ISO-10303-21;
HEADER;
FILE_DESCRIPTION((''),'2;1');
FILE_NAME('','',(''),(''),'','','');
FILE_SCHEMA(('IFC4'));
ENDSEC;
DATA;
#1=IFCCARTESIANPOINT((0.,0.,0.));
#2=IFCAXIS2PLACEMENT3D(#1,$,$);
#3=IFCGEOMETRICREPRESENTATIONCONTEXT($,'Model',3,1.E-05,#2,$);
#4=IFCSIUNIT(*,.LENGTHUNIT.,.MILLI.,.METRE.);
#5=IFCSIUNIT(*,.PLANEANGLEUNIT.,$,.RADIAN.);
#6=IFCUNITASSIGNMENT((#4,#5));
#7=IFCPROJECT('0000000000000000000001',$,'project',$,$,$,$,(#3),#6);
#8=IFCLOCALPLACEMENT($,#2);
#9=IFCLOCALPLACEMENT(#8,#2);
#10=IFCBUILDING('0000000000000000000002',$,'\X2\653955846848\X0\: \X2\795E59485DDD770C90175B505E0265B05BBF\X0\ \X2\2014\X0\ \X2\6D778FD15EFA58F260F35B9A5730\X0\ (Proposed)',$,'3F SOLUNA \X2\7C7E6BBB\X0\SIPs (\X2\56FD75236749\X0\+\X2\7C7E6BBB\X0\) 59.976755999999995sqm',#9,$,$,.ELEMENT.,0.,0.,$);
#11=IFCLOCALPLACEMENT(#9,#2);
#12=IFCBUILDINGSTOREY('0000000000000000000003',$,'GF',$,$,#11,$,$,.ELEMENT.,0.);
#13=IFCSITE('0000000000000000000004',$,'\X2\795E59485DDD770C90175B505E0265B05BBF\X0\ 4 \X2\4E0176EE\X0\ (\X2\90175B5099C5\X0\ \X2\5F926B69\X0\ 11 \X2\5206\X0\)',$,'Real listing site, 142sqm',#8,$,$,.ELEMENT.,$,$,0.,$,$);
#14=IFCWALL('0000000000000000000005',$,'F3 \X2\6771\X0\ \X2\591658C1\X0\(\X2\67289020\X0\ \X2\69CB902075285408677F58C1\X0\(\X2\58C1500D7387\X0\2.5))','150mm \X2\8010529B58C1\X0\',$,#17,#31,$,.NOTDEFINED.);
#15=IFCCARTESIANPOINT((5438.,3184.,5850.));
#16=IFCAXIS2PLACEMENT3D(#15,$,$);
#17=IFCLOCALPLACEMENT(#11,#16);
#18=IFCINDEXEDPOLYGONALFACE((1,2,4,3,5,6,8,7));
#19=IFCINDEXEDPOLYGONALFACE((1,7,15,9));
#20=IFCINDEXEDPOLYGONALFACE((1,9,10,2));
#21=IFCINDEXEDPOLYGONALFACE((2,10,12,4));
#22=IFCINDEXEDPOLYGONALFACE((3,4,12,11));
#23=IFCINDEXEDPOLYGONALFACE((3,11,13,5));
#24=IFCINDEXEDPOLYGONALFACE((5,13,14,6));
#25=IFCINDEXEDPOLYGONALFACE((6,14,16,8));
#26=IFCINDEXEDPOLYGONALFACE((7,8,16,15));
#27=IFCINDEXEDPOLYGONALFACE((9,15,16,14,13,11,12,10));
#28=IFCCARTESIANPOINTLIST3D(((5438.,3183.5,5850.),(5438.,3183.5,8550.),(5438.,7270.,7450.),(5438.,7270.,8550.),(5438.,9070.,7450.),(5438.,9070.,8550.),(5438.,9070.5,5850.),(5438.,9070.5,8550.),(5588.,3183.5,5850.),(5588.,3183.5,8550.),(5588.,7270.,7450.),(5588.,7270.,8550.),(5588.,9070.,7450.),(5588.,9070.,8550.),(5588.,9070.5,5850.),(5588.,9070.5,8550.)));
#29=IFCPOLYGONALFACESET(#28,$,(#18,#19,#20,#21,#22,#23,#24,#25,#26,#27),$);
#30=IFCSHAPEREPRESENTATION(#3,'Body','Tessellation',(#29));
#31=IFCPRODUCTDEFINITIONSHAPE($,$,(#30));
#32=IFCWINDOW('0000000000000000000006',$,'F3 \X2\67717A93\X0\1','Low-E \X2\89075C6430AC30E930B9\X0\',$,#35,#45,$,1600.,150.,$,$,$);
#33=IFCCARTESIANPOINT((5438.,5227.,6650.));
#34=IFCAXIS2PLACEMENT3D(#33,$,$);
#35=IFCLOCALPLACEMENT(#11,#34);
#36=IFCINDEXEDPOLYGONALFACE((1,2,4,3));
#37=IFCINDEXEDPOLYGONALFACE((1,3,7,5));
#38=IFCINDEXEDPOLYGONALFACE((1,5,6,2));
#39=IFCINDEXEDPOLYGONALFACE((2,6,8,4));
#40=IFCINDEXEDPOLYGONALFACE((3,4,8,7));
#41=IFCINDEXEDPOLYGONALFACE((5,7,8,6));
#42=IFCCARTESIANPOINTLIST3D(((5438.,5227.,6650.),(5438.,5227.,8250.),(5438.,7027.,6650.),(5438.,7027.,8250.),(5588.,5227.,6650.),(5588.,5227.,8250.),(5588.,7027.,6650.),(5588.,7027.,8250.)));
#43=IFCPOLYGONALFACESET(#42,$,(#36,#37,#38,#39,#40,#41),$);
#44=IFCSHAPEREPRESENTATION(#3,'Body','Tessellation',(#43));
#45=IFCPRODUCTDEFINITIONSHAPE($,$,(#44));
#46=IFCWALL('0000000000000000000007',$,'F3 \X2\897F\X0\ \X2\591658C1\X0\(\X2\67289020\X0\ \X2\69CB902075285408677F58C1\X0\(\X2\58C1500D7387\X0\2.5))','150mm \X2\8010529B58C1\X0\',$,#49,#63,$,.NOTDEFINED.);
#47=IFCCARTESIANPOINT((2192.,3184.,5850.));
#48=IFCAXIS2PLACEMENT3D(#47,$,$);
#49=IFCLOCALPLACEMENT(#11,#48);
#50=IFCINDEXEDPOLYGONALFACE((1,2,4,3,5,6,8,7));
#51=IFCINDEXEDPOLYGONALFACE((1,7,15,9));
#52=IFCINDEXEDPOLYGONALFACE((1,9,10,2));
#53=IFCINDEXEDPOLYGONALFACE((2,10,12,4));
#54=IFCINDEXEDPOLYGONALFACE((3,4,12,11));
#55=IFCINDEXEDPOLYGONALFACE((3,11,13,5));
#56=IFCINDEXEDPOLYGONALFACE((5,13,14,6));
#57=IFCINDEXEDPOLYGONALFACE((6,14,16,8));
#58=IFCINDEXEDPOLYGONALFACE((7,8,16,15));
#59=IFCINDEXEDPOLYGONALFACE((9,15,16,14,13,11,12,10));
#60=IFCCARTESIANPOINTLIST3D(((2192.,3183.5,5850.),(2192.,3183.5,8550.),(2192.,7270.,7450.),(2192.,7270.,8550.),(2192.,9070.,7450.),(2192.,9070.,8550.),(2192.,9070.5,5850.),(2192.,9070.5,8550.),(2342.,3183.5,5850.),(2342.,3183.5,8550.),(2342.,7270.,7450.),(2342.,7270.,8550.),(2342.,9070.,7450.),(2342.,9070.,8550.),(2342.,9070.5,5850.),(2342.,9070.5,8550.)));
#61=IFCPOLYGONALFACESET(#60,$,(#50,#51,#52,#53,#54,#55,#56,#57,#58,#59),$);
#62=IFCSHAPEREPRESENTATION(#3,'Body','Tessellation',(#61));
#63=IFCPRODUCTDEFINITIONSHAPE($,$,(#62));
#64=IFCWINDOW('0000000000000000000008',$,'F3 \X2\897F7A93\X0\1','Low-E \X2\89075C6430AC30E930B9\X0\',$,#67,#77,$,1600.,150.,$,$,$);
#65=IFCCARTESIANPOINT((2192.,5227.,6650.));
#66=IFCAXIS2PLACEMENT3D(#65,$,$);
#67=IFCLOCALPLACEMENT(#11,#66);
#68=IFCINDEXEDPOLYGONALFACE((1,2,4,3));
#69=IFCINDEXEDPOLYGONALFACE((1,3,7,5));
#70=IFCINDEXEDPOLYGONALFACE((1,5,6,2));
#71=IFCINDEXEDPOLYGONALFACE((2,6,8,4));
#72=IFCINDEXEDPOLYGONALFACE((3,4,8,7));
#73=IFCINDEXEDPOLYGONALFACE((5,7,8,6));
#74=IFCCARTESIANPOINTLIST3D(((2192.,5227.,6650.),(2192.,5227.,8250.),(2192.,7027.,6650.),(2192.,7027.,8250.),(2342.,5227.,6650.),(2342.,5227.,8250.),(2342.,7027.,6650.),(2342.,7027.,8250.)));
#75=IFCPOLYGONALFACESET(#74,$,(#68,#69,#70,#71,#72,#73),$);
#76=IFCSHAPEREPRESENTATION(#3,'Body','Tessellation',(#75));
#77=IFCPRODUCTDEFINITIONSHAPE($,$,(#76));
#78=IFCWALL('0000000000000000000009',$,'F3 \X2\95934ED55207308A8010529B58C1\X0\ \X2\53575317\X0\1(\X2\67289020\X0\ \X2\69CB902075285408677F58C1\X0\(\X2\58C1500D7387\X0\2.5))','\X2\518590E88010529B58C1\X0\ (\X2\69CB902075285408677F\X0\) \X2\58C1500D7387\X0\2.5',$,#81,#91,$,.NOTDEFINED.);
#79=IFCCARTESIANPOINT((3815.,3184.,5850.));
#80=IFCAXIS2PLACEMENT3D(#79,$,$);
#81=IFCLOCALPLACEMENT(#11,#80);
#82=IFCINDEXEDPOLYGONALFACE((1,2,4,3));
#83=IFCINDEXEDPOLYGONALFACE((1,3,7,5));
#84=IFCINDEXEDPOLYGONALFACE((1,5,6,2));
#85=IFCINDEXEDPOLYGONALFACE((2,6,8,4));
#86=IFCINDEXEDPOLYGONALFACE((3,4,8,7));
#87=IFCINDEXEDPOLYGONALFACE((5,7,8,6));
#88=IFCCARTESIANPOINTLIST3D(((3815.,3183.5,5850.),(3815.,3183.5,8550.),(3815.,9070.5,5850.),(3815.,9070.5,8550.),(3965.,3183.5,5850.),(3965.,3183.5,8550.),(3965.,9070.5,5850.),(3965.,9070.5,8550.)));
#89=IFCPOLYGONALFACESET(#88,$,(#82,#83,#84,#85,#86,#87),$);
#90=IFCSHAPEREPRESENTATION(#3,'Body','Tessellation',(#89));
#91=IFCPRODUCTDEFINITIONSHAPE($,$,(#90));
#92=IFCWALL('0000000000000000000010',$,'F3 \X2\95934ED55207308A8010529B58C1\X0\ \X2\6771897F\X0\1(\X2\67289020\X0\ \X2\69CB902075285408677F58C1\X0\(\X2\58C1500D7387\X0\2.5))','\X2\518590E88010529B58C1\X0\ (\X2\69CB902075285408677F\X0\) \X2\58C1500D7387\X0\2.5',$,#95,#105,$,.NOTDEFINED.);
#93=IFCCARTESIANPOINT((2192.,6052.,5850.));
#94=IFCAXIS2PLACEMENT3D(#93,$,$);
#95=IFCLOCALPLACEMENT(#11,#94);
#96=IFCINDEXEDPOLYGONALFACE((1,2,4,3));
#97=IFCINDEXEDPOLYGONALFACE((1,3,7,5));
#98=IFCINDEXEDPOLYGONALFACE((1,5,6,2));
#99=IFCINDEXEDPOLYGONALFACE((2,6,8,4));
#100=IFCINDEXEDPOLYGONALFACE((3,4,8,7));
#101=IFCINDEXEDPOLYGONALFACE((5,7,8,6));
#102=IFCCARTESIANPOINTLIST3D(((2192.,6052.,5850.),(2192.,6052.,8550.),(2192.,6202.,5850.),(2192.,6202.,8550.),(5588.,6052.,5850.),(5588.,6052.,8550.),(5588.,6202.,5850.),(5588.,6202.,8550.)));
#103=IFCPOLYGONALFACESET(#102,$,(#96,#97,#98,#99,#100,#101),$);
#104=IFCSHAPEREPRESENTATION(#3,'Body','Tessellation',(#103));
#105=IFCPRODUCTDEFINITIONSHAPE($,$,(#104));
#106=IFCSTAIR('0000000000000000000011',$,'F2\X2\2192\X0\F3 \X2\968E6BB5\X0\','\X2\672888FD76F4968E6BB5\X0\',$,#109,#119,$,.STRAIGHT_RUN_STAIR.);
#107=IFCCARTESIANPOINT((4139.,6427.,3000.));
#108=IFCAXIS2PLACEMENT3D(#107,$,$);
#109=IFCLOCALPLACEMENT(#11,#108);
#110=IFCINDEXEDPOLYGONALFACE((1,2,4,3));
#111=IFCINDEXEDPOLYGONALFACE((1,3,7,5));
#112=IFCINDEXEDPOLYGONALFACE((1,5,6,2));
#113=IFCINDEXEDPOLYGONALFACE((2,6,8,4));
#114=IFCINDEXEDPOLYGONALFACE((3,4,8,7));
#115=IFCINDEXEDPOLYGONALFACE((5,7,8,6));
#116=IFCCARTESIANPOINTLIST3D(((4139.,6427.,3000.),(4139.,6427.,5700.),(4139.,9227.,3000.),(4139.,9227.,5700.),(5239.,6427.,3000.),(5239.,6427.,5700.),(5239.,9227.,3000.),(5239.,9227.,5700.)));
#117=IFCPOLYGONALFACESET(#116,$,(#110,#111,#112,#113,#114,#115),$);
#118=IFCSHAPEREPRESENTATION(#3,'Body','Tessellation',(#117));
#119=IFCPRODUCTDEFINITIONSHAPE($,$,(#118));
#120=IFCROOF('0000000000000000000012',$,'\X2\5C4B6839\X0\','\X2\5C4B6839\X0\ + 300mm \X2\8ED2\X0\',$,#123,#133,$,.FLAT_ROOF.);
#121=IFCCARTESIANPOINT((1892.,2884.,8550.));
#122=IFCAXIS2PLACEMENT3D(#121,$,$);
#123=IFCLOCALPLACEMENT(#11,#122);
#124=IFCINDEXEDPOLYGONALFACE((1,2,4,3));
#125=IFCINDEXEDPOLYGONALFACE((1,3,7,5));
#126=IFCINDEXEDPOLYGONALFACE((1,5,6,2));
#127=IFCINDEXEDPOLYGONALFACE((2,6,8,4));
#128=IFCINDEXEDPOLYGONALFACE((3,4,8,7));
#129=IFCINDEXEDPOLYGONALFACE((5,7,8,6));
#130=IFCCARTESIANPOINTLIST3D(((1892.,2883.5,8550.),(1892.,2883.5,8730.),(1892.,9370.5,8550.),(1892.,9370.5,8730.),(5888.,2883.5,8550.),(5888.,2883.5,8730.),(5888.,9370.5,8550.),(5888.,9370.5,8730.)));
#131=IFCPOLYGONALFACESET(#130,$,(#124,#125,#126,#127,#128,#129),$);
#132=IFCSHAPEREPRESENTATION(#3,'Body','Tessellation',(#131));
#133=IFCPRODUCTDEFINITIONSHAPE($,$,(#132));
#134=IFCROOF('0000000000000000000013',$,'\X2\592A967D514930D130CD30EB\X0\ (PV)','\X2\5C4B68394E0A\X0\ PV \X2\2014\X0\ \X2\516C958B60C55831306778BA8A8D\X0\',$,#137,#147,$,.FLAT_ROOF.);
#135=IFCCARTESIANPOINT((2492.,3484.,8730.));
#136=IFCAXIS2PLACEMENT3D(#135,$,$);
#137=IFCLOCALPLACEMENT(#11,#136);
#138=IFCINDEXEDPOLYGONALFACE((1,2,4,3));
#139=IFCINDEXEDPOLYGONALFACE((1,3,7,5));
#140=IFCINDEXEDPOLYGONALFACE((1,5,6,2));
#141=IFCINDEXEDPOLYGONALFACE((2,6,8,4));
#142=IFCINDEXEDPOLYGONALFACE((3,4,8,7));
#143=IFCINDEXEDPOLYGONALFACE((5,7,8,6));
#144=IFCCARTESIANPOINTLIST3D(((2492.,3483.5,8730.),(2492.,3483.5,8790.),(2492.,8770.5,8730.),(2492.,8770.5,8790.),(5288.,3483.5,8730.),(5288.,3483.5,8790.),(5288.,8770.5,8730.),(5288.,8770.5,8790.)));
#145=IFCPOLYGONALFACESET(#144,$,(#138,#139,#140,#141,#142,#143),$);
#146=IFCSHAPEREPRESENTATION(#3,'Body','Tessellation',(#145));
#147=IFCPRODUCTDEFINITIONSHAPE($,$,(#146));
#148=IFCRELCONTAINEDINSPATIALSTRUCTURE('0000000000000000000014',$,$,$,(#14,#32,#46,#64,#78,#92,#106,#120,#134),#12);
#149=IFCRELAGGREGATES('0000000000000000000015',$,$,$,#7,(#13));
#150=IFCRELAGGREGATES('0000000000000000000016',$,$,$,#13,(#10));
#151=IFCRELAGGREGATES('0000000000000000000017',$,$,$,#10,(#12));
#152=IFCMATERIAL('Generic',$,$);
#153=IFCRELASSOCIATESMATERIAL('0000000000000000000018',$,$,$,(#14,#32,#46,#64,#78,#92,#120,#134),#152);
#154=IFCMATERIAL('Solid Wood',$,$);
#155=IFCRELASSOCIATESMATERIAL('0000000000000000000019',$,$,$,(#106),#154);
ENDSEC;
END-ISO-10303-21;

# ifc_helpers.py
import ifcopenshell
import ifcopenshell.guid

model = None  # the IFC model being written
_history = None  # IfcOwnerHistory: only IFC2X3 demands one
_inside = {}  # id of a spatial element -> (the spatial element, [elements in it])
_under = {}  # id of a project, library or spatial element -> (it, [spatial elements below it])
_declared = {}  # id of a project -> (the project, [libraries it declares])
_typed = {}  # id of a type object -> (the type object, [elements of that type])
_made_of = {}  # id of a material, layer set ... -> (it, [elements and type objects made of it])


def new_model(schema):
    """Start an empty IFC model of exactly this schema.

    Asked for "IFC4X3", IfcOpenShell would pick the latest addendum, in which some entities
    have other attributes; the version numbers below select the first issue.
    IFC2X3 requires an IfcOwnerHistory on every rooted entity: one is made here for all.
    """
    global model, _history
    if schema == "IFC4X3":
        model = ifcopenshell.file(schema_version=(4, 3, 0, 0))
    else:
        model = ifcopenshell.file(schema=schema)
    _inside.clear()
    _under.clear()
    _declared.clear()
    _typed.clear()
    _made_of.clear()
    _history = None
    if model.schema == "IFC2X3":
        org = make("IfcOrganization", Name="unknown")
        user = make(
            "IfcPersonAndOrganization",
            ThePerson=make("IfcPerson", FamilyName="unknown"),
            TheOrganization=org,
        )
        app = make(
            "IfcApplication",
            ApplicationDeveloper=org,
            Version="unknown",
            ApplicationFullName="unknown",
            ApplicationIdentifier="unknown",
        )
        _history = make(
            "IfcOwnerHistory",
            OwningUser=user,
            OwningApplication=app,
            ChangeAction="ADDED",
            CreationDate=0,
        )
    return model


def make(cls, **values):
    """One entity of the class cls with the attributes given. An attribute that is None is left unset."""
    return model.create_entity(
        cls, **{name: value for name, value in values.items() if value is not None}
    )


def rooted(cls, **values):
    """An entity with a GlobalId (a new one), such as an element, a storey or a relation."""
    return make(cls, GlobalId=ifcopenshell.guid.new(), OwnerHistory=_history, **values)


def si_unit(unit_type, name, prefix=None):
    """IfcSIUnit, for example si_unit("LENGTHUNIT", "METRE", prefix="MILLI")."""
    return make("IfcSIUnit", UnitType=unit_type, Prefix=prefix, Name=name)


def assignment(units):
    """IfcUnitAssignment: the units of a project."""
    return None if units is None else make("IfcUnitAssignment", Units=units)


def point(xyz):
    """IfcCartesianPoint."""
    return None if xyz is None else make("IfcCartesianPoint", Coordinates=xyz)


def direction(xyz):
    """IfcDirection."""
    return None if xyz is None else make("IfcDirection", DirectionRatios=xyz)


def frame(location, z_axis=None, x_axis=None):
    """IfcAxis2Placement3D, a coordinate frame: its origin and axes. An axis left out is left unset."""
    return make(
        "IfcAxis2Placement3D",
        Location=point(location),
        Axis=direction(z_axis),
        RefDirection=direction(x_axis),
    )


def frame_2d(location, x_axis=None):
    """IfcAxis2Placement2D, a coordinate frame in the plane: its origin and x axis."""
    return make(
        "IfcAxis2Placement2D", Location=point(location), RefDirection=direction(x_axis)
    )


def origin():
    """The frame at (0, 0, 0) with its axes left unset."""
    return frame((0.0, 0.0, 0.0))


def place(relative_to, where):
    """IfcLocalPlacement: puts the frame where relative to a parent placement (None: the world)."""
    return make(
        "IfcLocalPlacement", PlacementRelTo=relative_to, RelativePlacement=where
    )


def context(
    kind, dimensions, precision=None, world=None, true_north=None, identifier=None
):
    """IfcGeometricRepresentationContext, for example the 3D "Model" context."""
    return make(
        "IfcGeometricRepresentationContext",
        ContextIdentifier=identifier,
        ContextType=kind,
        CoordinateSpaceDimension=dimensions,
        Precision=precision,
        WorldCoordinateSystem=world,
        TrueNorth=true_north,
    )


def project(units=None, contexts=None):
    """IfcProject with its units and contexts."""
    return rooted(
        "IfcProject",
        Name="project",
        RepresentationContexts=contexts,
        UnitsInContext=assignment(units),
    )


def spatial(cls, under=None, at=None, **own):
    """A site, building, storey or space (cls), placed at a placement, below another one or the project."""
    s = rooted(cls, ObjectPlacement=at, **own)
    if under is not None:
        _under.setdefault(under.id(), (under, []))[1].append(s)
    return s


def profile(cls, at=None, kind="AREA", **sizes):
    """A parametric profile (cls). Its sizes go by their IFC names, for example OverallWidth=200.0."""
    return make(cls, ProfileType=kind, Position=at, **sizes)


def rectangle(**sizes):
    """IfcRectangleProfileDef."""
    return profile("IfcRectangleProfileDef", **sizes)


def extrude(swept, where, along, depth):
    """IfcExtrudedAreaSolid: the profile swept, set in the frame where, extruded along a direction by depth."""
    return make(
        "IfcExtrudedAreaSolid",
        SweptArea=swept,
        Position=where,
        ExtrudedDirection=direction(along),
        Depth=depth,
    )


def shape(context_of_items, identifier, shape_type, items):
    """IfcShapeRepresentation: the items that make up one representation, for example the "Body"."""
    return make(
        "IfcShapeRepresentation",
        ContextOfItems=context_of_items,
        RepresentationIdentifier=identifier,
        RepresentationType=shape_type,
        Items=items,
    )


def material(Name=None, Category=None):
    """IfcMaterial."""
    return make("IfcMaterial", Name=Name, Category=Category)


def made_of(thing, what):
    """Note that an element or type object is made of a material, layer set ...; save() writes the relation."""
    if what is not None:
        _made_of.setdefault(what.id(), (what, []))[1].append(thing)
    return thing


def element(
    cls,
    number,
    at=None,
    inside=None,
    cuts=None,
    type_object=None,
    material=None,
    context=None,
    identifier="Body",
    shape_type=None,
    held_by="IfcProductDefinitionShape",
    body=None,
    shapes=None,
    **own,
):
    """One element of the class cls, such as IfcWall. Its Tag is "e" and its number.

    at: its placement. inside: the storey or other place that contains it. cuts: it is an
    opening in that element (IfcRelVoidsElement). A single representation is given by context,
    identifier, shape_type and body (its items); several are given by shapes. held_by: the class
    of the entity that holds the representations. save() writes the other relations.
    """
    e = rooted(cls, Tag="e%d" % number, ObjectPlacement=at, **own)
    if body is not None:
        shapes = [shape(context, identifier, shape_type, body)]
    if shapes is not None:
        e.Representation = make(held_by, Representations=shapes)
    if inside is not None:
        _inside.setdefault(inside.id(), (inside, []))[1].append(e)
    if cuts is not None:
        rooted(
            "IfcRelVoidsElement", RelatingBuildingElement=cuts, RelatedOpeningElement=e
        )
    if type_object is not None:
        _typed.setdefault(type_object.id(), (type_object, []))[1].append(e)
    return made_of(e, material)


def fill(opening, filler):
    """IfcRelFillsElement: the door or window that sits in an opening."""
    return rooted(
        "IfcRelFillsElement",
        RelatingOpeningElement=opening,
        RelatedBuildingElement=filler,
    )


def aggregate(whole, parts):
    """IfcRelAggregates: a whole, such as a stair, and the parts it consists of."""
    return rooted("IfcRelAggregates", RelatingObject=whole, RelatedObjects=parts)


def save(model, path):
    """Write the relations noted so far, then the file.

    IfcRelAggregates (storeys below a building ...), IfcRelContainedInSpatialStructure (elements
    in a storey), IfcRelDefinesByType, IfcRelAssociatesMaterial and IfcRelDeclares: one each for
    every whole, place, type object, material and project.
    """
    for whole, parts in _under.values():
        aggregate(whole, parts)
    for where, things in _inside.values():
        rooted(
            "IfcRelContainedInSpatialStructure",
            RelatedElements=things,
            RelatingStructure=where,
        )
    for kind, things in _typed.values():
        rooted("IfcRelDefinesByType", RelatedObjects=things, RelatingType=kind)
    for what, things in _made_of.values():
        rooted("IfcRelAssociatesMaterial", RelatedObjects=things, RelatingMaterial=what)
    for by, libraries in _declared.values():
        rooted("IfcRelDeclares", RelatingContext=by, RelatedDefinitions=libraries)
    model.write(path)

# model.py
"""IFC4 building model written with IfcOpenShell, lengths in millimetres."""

from ifc_helpers import new_model, si_unit, frame, frame_2d, origin, place, context, project, spatial, rectangle, extrude, material, element, fill, save


model = new_model("IFC4")

# Units and contexts
model_context = context("Model", 3, precision=1e-05, world=origin())
ifc_project = project(units=[si_unit("LENGTHUNIT", "METRE", prefix="MILLI"), si_unit("PLANEANGLEUNIT", "RADIAN")], contexts=[model_context])

# Site, building, storey
site_placement = place(None, origin())
site = spatial("IfcSite", under=ifc_project, at=site_placement, Name="神奈川県逗子市新宿 4 丁目 (逗子駅 徒歩 11 分)", ObjectType="Real listing site, 142sqm", CompositionType="ELEMENT", RefElevation=0.0)
building_placement = place(site_placement, origin())
building = spatial("IfcBuilding", under=site, at=building_placement, Name="改善案: 神奈川県逗子市新宿 — 海近建売想定地 (Proposed)", ObjectType="3F SOLUNA 籾殻SIPs (国産杉+籾殻) 59.976755999999995sqm", CompositionType="ELEMENT", ElevationOfRefHeight=0.0, ElevationOfTerrain=0.0)
storey_placement = place(building_placement, origin())
storey = spatial("IfcBuildingStorey", under=building, at=storey_placement, Name="GF", CompositionType="ELEMENT", Elevation=0.0)

# Shared definitions
ifc_material_1 = material(Name="Generic")

# Walls, openings, windows
wall_1_placement = place(storey_placement, frame((5438.0, 3184.0, 5850.0)))
wall_1 = element("IfcWall", 1, at=wall_1_placement, inside=storey, material=ifc_material_1, Name="F3 東 外壁(木造 構造用合板壁(壁倍率2.5))", Description="150mm 耐力壁", PredefinedType="NOTDEFINED", context=model_context, shape_type="SweptSolid", body=[
    extrude(rectangle(XDim=150.0, YDim=5887.0, at=frame_2d((75.0, 2943.0))), frame((5438.0, 3184.0, 5850.0)), (0.0, 0.0, 1.0), 2700.0),
])
opening_1_placement = place(storey_placement, frame((5438.0, 5227.0, 6650.0)))
opening_1 = element("IfcOpeningElement", 2, at=opening_1_placement, cuts=wall_1, PredefinedType="NOTDEFINED", context=model_context, shape_type="SweptSolid", body=[
    extrude(rectangle(XDim=150.0, YDim=1800.0, at=frame_2d((75.0, 900.0))), frame((5438.0, 5227.0, 6650.0)), (0.0, 0.0, 1.0), 1600.0),
])
window_1_placement = place(storey_placement, frame((5438.0, 5227.0, 6650.0)))
window_1 = element("IfcWindow", 3, at=window_1_placement, inside=storey, material=ifc_material_1, Name="F3 東窓1", Description="Low-E 複層ガラス", OverallHeight=1600.0, OverallWidth=150.0, context=model_context, shape_type="SweptSolid", body=[
    extrude(rectangle(XDim=150.0, YDim=1800.0, at=frame_2d((75.0, 900.0))), frame((5438.0, 5227.0, 6650.0)), (0.0, 0.0, 1.0), 1600.0),
])
fill(opening_1, window_1)
wall_2_placement = place(storey_placement, frame((2192.0, 3184.0, 5850.0)))
wall_2 = element("IfcWall", 4, at=wall_2_placement, inside=storey, material=ifc_material_1, Name="F3 西 外壁(木造 構造用合板壁(壁倍率2.5))", Description="150mm 耐力壁", PredefinedType="NOTDEFINED", context=model_context, shape_type="SweptSolid", body=[
    extrude(rectangle(XDim=150.0, YDim=5887.0, at=frame_2d((75.0, 2943.0))), frame((2192.0, 3184.0, 5850.0)), (0.0, 0.0, 1.0), 2700.0),
])
opening_2_placement = place(storey_placement, frame((2192.0, 5227.0, 6650.0)))
opening_2 = element("IfcOpeningElement", 5, at=opening_2_placement, cuts=wall_2, PredefinedType="NOTDEFINED", context=model_context, shape_type="SweptSolid", body=[
    extrude(rectangle(XDim=150.0, YDim=1800.0, at=frame_2d((75.0, 900.0))), frame((2192.0, 5227.0, 6650.0)), (0.0, 0.0, 1.0), 1600.0),
])
window_2_placement = place(storey_placement, frame((2192.0, 5227.0, 6650.0)))
window_2 = element("IfcWindow", 6, at=window_2_placement, inside=storey, material=ifc_material_1, Name="F3 西窓1", Description="Low-E 複層ガラス", OverallHeight=1600.0, OverallWidth=150.0, context=model_context, shape_type="SweptSolid", body=[
    extrude(rectangle(XDim=150.0, YDim=1800.0, at=frame_2d((75.0, 900.0))), frame((2192.0, 5227.0, 6650.0)), (0.0, 0.0, 1.0), 1600.0),
])
fill(opening_2, window_2)

# Walls
wall_3_placement = place(storey_placement, frame((3815.0, 3184.0, 5850.0)))
element("IfcWall", 7, at=wall_3_placement, inside=storey, material=ifc_material_1, Name="F3 間仕切り耐力壁 南北1(木造 構造用合板壁(壁倍率2.5))", Description="内部耐力壁 (構造用合板) 壁倍率2.5", PredefinedType="NOTDEFINED", context=model_context, shape_type="SweptSolid", body=[
    extrude(rectangle(XDim=150.0, YDim=5887.0, at=frame_2d((75.0, 2943.0))), frame((3815.0, 3184.0, 5850.0)), (0.0, 0.0, 1.0), 2700.0),
])
wall_4_placement = place(storey_placement, frame((2192.0, 6052.0, 5850.0)))
element("IfcWall", 8, at=wall_4_placement, inside=storey, material=ifc_material_1, Name="F3 間仕切り耐力壁 東西1(木造 構造用合板壁(壁倍率2.5))", Description="内部耐力壁 (構造用合板) 壁倍率2.5", PredefinedType="NOTDEFINED", context=model_context, shape_type="SweptSolid", body=[
    extrude(rectangle(XDim=3396.0, YDim=150.0, at=frame_2d((1698.0, 75.0))), frame((2192.0, 6052.0, 5850.0)), (0.0, 0.0, 1.0), 2700.0),
])

# Stair
ifc_material_2 = material(Name="Solid Wood")
stair_placement = place(storey_placement, frame((4139.0, 6427.0, 3000.0)))
element("IfcStair", 9, at=stair_placement, inside=storey, material=ifc_material_2, Name="F2→F3 階段", Description="木製直階段", PredefinedType="STRAIGHT_RUN_STAIR", context=model_context, shape_type="SweptSolid", body=[
    extrude(rectangle(XDim=1100.0, YDim=2800.0, at=frame_2d((550.0, 1400.0))), frame((4139.0, 6427.0, 3000.0)), (0.0, 0.0, 1.0), 2700.0),
])

# Roofs
roof_1_placement = place(storey_placement, frame((1892.0, 2884.0, 8550.0)))
element("IfcRoof", 10, at=roof_1_placement, inside=storey, material=ifc_material_1, Name="屋根", Description="屋根 + 300mm 軒", PredefinedType="FLAT_ROOF", context=model_context, shape_type="SweptSolid", body=[
    extrude(rectangle(XDim=3996.0, YDim=6487.0, at=frame_2d((1998.0, 3243.0))), frame((1892.0, 2884.0, 8550.0)), (0.0, 0.0, 1.0), 180.0),
])
roof_2_placement = place(storey_placement, frame((2492.0, 3484.0, 8730.0)))
element("IfcRoof", 11, at=roof_2_placement, inside=storey, material=ifc_material_1, Name="太陽光パネル (PV)", Description="屋根上 PV — 公開情報で確認", PredefinedType="FLAT_ROOF", context=model_context, shape_type="SweptSolid", body=[
    extrude(rectangle(XDim=2796.0, YDim=5287.0, at=frame_2d((1398.0, 2643.0))), frame((2492.0, 3484.0, 8730.0)), (0.0, 0.0, 1.0), 60.0),
])

save(model, "model.ifc")
